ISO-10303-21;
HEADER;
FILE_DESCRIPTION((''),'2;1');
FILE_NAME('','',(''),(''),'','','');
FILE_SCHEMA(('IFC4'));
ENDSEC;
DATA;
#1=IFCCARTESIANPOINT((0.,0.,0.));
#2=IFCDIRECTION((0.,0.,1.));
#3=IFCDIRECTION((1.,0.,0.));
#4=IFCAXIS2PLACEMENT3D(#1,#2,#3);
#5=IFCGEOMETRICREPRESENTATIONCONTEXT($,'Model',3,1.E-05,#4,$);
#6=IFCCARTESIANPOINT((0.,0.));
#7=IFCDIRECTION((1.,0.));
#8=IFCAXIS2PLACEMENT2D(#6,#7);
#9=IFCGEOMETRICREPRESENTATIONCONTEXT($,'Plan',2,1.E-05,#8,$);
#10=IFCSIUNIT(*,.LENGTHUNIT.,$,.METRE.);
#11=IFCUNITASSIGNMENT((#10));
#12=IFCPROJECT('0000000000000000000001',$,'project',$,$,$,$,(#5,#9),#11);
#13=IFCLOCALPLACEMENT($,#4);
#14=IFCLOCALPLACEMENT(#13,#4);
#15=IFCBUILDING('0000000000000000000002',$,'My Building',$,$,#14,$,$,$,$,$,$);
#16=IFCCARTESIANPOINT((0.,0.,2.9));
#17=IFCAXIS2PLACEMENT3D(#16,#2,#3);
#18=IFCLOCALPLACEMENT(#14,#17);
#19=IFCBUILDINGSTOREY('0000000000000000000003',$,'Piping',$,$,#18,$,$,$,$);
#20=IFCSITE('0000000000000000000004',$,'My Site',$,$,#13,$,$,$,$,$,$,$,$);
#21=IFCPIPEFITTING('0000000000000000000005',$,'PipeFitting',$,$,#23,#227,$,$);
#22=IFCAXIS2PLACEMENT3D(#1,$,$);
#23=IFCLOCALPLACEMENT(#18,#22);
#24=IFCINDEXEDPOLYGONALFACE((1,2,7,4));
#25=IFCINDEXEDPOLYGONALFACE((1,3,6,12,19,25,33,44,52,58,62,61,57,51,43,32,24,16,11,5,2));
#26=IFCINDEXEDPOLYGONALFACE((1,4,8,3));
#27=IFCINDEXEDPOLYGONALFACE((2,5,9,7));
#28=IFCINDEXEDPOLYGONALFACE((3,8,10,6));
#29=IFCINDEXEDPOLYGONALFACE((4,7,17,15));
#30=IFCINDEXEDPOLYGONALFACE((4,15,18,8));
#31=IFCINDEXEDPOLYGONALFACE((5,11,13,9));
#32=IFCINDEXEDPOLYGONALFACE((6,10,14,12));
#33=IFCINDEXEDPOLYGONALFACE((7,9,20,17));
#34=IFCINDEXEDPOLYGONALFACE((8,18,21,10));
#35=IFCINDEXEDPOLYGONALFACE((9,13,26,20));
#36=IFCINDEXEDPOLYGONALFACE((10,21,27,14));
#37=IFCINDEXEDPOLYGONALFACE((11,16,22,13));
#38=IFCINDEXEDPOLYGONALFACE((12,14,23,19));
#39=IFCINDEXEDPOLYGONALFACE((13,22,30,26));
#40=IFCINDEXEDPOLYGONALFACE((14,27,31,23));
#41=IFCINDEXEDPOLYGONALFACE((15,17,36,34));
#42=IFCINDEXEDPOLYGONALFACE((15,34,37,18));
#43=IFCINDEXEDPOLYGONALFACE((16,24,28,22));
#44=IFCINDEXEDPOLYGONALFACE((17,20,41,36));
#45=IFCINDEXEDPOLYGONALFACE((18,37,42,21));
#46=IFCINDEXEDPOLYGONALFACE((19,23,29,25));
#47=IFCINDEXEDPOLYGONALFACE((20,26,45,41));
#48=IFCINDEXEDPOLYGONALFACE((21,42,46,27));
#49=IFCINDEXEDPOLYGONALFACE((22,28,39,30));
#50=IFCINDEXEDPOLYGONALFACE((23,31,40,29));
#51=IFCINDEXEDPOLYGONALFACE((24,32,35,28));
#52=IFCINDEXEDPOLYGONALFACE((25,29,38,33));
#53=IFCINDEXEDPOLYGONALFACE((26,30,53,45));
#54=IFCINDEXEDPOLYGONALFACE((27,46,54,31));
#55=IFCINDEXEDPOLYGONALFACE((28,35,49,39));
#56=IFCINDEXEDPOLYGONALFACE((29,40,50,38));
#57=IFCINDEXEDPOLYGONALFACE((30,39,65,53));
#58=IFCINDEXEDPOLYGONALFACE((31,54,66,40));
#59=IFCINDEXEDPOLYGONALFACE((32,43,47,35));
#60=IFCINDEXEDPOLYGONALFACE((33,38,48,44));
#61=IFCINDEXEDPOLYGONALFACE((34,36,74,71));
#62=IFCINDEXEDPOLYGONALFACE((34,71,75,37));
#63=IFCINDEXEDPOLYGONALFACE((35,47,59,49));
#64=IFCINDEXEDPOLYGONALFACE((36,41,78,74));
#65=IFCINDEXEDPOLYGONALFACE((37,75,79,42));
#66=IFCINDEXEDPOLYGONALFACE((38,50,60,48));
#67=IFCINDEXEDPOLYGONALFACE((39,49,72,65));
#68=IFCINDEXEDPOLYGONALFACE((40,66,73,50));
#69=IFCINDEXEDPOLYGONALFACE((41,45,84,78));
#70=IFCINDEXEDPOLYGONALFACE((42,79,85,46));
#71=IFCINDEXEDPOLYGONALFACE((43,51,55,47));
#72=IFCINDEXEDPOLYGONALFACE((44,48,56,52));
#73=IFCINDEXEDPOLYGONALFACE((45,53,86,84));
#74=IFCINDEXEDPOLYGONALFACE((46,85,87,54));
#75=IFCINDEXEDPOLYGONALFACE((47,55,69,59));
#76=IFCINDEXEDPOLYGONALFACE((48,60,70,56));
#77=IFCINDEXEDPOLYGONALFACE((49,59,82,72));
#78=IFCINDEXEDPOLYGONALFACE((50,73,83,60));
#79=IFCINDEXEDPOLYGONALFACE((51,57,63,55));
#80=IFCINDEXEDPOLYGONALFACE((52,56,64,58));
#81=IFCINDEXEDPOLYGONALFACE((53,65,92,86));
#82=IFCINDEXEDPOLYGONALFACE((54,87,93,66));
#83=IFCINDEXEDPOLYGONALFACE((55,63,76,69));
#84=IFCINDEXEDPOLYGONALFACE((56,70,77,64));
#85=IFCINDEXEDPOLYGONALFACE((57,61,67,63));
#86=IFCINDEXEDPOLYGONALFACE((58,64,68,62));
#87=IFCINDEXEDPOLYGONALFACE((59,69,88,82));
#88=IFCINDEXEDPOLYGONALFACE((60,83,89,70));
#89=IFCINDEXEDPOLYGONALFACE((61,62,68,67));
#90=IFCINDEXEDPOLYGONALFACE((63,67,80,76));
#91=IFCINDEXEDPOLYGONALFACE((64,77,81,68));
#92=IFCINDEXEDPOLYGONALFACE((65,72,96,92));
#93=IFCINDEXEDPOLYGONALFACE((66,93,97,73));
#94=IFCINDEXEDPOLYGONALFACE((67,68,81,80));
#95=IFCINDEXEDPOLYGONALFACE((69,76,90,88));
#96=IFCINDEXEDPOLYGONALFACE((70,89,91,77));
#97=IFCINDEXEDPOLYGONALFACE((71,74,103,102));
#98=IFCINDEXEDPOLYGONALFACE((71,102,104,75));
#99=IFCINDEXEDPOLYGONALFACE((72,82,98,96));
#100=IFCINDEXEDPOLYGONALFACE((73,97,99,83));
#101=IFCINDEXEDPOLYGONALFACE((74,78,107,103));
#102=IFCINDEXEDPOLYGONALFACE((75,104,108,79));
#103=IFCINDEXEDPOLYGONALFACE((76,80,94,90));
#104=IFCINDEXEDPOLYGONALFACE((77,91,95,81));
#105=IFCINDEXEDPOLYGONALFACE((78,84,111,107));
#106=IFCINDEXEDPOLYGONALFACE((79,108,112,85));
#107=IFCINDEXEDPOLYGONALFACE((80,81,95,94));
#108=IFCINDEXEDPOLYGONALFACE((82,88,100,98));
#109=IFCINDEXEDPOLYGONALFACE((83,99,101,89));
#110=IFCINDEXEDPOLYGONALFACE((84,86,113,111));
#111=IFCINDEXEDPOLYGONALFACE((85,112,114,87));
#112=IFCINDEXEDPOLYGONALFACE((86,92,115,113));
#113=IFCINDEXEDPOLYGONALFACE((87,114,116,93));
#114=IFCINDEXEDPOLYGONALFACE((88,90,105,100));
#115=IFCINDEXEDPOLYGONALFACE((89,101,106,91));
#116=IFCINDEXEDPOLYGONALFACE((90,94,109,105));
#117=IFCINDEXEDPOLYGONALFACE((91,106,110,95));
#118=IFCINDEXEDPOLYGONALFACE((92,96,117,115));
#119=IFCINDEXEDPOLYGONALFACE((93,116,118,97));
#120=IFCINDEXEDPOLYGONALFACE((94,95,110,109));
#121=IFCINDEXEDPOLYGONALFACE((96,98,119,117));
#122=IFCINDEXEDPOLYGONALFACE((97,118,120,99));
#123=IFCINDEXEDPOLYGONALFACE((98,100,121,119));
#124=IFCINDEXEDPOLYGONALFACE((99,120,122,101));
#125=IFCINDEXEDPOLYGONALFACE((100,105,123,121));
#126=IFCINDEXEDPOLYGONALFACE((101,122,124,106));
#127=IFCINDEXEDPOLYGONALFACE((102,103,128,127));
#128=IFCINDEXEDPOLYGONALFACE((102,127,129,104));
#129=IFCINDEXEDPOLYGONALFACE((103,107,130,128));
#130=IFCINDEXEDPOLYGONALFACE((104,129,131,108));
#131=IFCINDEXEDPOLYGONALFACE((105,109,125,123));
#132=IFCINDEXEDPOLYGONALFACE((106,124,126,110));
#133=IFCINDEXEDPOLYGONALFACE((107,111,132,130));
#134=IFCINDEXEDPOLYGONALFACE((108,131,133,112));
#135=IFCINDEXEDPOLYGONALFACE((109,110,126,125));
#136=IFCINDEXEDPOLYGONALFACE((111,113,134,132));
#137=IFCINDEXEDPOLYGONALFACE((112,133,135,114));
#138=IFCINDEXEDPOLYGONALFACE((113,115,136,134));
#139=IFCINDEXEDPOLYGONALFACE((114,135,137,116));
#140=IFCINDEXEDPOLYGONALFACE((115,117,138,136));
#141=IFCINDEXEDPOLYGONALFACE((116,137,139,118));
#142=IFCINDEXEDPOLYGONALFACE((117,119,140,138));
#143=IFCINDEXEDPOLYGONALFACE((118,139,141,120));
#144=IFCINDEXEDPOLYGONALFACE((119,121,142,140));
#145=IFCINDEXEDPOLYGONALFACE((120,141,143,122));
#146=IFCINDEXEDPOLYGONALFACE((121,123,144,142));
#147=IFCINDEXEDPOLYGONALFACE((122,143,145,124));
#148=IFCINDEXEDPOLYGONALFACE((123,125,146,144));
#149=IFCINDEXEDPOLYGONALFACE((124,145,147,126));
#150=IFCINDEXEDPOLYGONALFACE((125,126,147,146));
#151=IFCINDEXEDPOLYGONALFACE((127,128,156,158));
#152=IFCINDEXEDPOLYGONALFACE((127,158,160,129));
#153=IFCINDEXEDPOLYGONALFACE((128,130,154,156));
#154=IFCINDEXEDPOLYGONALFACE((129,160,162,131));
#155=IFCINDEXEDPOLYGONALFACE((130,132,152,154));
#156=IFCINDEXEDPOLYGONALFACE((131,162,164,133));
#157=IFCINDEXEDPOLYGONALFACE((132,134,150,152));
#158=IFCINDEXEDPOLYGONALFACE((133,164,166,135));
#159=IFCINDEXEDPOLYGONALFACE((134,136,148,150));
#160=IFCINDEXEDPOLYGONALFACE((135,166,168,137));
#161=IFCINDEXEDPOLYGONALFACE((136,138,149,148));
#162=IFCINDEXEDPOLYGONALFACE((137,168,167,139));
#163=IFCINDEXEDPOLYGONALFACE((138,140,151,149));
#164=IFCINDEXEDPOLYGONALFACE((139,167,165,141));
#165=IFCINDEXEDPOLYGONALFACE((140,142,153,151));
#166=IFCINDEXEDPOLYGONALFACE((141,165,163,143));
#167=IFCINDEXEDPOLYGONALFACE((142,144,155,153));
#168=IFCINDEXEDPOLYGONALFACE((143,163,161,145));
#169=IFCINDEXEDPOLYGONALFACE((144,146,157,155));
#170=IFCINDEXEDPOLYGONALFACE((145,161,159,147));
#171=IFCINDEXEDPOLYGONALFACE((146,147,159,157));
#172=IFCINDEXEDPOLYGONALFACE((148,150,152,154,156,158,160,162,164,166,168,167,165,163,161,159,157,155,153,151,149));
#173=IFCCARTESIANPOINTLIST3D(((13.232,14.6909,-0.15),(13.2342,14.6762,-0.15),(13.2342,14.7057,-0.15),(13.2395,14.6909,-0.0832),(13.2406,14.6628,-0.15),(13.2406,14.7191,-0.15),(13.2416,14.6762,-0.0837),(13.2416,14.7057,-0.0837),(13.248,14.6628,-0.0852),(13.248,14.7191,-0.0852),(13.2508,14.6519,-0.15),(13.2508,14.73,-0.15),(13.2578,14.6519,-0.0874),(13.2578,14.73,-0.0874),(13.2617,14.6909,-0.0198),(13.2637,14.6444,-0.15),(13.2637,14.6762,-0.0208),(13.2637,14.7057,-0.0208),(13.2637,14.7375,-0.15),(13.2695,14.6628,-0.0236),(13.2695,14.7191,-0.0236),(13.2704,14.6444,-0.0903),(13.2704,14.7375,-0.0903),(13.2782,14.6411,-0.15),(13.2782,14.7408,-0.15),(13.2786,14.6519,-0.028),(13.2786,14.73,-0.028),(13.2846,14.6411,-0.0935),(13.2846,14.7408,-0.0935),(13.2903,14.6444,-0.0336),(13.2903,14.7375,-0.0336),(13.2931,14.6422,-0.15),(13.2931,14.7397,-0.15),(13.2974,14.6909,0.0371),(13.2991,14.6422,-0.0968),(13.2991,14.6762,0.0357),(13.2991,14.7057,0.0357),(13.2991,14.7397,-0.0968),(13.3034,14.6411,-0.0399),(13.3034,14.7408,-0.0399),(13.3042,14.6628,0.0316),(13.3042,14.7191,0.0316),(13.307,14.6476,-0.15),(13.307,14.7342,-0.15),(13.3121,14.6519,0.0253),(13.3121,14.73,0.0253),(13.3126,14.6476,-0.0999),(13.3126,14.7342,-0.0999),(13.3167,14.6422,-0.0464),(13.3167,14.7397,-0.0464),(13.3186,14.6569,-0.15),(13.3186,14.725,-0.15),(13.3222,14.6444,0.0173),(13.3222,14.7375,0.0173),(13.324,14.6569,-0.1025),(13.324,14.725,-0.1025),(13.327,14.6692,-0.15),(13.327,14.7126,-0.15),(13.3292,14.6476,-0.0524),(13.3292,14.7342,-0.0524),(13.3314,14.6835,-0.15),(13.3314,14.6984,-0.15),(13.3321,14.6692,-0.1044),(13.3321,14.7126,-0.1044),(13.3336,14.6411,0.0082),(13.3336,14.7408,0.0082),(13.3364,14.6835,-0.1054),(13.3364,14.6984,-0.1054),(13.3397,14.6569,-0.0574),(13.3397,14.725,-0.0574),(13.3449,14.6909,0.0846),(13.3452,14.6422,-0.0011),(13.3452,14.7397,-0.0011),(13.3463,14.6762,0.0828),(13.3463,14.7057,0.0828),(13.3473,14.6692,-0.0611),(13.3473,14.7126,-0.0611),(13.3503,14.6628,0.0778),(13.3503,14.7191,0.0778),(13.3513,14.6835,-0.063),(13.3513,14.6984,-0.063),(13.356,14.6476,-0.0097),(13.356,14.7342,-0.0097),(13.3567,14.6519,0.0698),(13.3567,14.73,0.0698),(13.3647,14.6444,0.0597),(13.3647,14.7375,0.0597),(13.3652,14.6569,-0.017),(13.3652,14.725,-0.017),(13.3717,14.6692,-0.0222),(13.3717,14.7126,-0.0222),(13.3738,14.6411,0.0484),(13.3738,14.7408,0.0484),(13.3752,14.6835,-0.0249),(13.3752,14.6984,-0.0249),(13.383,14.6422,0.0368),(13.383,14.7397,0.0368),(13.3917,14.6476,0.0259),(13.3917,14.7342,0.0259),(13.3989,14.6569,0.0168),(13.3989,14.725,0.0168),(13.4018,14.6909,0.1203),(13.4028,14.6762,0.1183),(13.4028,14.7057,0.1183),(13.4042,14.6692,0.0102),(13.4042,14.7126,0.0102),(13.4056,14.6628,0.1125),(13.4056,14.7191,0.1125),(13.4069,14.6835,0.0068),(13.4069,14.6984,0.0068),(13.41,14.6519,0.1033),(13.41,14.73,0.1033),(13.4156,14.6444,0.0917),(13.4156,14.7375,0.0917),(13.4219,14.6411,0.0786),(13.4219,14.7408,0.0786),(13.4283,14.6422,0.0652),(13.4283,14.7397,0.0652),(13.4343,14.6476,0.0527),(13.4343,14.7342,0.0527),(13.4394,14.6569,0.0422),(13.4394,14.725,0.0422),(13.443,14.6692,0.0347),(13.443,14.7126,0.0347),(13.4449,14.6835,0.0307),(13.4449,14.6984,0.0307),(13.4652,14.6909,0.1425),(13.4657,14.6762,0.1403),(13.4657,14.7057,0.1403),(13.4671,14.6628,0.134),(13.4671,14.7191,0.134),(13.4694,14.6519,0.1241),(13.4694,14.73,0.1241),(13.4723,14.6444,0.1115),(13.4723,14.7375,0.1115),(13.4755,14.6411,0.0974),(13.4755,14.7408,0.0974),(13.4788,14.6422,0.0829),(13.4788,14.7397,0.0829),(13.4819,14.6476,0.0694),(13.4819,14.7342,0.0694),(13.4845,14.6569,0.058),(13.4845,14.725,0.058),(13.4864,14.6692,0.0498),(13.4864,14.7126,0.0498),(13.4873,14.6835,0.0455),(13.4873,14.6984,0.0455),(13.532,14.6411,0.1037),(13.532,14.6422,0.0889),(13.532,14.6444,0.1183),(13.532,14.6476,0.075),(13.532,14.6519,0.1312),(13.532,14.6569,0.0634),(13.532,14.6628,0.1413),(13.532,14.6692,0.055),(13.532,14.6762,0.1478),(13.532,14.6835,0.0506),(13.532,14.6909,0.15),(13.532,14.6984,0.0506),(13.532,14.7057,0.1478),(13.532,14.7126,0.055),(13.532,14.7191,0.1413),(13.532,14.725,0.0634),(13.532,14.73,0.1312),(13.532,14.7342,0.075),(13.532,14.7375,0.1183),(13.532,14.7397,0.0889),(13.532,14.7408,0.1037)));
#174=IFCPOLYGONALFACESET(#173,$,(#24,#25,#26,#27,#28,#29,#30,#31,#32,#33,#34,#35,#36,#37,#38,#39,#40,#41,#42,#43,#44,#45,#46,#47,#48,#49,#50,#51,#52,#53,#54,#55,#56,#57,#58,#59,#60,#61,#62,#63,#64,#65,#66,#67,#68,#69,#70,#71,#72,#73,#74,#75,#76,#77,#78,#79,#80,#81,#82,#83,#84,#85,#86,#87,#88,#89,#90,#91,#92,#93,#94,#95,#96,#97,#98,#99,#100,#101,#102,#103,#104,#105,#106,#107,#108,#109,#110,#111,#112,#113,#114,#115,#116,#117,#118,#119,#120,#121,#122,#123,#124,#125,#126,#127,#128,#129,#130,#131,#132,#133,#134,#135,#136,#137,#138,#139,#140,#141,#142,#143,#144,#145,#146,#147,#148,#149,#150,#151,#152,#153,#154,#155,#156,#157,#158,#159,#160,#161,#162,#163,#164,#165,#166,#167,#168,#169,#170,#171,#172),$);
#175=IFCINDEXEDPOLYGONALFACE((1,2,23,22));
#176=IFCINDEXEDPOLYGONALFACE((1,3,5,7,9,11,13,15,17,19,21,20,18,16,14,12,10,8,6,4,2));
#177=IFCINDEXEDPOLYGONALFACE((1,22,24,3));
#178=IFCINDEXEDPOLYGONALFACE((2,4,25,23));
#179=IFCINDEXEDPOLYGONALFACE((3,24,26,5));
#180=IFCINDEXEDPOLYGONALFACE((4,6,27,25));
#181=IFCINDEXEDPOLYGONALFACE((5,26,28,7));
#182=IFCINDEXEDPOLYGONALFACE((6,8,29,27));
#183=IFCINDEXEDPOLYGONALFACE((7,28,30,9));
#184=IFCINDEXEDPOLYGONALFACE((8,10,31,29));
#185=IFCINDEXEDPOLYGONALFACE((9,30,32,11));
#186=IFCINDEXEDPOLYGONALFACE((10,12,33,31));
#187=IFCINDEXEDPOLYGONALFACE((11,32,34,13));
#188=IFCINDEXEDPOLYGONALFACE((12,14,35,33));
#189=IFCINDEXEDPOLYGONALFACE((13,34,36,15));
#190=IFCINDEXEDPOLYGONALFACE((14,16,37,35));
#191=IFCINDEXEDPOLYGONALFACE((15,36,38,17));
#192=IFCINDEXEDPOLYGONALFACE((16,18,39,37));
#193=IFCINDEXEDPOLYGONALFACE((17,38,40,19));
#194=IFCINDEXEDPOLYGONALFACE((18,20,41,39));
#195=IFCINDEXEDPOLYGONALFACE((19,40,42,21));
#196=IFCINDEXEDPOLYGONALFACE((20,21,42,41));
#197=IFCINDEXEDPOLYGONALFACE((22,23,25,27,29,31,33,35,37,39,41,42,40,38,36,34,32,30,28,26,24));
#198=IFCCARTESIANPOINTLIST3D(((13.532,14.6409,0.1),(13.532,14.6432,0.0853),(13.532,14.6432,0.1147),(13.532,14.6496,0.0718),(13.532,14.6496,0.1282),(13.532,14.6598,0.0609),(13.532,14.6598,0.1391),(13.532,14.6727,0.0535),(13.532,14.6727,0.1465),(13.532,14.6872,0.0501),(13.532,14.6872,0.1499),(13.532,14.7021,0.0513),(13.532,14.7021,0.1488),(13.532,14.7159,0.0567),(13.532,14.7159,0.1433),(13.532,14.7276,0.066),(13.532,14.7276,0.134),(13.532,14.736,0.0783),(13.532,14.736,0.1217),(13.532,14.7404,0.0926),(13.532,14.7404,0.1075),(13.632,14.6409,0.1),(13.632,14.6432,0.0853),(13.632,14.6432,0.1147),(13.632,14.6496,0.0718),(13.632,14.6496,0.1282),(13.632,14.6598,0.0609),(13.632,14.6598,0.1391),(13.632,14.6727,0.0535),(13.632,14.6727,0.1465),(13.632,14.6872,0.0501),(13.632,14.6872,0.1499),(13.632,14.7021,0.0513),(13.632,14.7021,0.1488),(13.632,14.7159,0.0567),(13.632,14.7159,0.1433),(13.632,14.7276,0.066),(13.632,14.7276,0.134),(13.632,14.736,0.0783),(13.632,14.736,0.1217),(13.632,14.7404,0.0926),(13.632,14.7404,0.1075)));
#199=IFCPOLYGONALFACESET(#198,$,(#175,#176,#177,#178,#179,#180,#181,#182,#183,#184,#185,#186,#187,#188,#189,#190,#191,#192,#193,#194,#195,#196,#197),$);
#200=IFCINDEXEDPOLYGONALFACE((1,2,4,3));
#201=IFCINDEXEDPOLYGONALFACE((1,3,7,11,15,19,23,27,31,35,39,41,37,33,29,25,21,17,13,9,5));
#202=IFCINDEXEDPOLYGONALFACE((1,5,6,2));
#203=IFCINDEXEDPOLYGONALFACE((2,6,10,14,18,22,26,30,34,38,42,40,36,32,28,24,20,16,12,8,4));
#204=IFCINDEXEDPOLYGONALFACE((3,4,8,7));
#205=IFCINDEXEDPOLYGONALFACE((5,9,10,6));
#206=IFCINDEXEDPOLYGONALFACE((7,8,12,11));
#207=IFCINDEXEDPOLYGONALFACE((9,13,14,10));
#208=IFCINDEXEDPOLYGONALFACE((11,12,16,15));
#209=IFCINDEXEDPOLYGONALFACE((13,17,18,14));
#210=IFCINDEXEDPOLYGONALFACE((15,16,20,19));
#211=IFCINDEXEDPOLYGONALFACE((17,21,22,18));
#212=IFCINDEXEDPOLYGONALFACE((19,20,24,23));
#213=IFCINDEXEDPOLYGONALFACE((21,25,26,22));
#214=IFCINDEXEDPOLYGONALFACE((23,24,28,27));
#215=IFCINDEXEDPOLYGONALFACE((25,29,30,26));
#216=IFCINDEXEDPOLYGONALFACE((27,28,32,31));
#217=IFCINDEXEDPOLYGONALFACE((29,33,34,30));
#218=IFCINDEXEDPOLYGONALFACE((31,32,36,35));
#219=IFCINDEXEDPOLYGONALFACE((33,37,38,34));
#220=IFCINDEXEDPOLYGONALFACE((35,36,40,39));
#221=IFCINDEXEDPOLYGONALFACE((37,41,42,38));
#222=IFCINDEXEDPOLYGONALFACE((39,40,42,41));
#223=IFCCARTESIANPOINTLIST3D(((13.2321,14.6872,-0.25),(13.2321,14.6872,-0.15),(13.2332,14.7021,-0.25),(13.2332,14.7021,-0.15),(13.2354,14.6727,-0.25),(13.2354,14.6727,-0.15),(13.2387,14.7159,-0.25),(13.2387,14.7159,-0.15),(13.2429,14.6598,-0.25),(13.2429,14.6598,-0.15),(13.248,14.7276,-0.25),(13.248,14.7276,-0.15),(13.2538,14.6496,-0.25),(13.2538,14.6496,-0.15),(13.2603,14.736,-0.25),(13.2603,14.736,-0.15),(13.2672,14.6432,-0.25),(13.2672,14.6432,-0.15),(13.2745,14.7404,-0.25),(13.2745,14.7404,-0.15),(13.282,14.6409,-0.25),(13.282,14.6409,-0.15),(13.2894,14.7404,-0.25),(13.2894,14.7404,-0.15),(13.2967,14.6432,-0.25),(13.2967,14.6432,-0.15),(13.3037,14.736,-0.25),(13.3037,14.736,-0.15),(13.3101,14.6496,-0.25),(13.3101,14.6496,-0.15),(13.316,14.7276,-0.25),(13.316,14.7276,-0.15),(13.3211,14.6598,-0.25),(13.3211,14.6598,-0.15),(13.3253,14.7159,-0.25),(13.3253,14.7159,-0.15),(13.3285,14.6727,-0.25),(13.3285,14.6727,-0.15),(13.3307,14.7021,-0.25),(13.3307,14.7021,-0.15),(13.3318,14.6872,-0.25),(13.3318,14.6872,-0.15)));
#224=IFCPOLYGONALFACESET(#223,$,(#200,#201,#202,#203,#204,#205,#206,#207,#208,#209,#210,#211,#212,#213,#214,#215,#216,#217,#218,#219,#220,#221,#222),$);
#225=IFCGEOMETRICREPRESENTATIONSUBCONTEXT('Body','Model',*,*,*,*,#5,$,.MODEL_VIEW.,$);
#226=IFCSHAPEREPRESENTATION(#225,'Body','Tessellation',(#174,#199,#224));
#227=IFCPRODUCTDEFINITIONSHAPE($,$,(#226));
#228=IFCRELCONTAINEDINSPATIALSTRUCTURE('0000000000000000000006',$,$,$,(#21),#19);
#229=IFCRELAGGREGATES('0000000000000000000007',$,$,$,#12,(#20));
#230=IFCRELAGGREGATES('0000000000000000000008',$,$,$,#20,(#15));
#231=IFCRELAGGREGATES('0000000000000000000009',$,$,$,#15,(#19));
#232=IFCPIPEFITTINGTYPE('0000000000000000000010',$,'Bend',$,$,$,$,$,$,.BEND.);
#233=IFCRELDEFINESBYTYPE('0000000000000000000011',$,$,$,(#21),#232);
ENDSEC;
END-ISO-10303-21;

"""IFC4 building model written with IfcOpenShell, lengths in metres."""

from ifc_helpers import new_model, entity, si_unit, frame, origin_with_axes, origin_2d_with_axis, place, context, subcontext, project, spatial, circle, extrude, source, transform, mapped, type_object, type_shapes, element, save


model = new_model("IFC4")

# Units and contexts
model_context = context("Model", 3, precision=1e-05, world=origin_with_axes())
plan_context = context("Plan", 2, precision=1e-05, world=origin_2d_with_axis())
body_context = subcontext(model_context, "Body", "Model", "MODEL_VIEW")
ifc_project = project(units=[si_unit("LENGTHUNIT", "METRE")], contexts=[model_context, plan_context])

# Site, building, storey
site_placement = place(None, origin_with_axes())
site = spatial("IfcSite", under=ifc_project, at=site_placement, Name="My Site")
building_placement = place(site_placement, origin_with_axes())
building = spatial("IfcBuilding", under=site, at=building_placement, Name="My Building")
storey_placement = place(building_placement, frame((0.0, 0.0, 2.9), z_axis=(0.0, 0.0, 1.0), x_axis=(1.0, 0.0, 0.0)))
storey = spatial("IfcBuildingStorey", under=building, at=storey_placement, Name="Piping")

# Pipe fitting
pipe_fitting_type = type_object("IfcPipeFittingType", Name="Bend", PredefinedType="BEND")
shared_shape = source(origin_with_axes(), body_context, "Body", "SolidModel", [
    entity("IfcSweptDiskSolid", entity("IfcIndexedPolyCurve", entity("IfcCartesianPointList3D", [[0.0, 0.0, 0.1], [0.0, -0.0732, 0.2768], [0.0, -0.25, 0.35]]), [entity("IfcArcIndex", [1, 2, 3])]), 0.05),
    extrude(circle(Radius=0.05), origin_with_axes(), (0.0, 0.0, 1.0), 0.1),
    extrude(circle(Radius=0.05), frame((0.0, -0.25, 0.35), z_axis=(0.0, -1.0, -0.000001), x_axis=(1.0, 0.0, 0.0)), (0.0, 0.0, 1.0), 0.1),
])
type_shapes(pipe_fitting_type, [shared_shape])
for number, where, z_axis, x_axis, name in (
    (1, (13.632, 14.6909, 0.1), (-1.0, 0.0, 0.000001), (0.0, -1.0, 0.0), "PipeFitting"),
):
    element("IfcPipeFitting", number, at=place(storey_placement, frame(where, z_axis=z_axis, x_axis=x_axis)), inside=storey, type_object=pipe_fitting_type, Name=name, context=body_context, shape_type="MappedRepresentation", body=[
        mapped(shared_shape, transform((0.0, 0.0, 0.0), x_axis=(1.0, 0.0, 0.0), y_axis=(0.0, 1.0, 0.0), z_axis=(0.0, 0.0, 1.0), scale=1.0)),
    ])

save(model, "model.ifc")
